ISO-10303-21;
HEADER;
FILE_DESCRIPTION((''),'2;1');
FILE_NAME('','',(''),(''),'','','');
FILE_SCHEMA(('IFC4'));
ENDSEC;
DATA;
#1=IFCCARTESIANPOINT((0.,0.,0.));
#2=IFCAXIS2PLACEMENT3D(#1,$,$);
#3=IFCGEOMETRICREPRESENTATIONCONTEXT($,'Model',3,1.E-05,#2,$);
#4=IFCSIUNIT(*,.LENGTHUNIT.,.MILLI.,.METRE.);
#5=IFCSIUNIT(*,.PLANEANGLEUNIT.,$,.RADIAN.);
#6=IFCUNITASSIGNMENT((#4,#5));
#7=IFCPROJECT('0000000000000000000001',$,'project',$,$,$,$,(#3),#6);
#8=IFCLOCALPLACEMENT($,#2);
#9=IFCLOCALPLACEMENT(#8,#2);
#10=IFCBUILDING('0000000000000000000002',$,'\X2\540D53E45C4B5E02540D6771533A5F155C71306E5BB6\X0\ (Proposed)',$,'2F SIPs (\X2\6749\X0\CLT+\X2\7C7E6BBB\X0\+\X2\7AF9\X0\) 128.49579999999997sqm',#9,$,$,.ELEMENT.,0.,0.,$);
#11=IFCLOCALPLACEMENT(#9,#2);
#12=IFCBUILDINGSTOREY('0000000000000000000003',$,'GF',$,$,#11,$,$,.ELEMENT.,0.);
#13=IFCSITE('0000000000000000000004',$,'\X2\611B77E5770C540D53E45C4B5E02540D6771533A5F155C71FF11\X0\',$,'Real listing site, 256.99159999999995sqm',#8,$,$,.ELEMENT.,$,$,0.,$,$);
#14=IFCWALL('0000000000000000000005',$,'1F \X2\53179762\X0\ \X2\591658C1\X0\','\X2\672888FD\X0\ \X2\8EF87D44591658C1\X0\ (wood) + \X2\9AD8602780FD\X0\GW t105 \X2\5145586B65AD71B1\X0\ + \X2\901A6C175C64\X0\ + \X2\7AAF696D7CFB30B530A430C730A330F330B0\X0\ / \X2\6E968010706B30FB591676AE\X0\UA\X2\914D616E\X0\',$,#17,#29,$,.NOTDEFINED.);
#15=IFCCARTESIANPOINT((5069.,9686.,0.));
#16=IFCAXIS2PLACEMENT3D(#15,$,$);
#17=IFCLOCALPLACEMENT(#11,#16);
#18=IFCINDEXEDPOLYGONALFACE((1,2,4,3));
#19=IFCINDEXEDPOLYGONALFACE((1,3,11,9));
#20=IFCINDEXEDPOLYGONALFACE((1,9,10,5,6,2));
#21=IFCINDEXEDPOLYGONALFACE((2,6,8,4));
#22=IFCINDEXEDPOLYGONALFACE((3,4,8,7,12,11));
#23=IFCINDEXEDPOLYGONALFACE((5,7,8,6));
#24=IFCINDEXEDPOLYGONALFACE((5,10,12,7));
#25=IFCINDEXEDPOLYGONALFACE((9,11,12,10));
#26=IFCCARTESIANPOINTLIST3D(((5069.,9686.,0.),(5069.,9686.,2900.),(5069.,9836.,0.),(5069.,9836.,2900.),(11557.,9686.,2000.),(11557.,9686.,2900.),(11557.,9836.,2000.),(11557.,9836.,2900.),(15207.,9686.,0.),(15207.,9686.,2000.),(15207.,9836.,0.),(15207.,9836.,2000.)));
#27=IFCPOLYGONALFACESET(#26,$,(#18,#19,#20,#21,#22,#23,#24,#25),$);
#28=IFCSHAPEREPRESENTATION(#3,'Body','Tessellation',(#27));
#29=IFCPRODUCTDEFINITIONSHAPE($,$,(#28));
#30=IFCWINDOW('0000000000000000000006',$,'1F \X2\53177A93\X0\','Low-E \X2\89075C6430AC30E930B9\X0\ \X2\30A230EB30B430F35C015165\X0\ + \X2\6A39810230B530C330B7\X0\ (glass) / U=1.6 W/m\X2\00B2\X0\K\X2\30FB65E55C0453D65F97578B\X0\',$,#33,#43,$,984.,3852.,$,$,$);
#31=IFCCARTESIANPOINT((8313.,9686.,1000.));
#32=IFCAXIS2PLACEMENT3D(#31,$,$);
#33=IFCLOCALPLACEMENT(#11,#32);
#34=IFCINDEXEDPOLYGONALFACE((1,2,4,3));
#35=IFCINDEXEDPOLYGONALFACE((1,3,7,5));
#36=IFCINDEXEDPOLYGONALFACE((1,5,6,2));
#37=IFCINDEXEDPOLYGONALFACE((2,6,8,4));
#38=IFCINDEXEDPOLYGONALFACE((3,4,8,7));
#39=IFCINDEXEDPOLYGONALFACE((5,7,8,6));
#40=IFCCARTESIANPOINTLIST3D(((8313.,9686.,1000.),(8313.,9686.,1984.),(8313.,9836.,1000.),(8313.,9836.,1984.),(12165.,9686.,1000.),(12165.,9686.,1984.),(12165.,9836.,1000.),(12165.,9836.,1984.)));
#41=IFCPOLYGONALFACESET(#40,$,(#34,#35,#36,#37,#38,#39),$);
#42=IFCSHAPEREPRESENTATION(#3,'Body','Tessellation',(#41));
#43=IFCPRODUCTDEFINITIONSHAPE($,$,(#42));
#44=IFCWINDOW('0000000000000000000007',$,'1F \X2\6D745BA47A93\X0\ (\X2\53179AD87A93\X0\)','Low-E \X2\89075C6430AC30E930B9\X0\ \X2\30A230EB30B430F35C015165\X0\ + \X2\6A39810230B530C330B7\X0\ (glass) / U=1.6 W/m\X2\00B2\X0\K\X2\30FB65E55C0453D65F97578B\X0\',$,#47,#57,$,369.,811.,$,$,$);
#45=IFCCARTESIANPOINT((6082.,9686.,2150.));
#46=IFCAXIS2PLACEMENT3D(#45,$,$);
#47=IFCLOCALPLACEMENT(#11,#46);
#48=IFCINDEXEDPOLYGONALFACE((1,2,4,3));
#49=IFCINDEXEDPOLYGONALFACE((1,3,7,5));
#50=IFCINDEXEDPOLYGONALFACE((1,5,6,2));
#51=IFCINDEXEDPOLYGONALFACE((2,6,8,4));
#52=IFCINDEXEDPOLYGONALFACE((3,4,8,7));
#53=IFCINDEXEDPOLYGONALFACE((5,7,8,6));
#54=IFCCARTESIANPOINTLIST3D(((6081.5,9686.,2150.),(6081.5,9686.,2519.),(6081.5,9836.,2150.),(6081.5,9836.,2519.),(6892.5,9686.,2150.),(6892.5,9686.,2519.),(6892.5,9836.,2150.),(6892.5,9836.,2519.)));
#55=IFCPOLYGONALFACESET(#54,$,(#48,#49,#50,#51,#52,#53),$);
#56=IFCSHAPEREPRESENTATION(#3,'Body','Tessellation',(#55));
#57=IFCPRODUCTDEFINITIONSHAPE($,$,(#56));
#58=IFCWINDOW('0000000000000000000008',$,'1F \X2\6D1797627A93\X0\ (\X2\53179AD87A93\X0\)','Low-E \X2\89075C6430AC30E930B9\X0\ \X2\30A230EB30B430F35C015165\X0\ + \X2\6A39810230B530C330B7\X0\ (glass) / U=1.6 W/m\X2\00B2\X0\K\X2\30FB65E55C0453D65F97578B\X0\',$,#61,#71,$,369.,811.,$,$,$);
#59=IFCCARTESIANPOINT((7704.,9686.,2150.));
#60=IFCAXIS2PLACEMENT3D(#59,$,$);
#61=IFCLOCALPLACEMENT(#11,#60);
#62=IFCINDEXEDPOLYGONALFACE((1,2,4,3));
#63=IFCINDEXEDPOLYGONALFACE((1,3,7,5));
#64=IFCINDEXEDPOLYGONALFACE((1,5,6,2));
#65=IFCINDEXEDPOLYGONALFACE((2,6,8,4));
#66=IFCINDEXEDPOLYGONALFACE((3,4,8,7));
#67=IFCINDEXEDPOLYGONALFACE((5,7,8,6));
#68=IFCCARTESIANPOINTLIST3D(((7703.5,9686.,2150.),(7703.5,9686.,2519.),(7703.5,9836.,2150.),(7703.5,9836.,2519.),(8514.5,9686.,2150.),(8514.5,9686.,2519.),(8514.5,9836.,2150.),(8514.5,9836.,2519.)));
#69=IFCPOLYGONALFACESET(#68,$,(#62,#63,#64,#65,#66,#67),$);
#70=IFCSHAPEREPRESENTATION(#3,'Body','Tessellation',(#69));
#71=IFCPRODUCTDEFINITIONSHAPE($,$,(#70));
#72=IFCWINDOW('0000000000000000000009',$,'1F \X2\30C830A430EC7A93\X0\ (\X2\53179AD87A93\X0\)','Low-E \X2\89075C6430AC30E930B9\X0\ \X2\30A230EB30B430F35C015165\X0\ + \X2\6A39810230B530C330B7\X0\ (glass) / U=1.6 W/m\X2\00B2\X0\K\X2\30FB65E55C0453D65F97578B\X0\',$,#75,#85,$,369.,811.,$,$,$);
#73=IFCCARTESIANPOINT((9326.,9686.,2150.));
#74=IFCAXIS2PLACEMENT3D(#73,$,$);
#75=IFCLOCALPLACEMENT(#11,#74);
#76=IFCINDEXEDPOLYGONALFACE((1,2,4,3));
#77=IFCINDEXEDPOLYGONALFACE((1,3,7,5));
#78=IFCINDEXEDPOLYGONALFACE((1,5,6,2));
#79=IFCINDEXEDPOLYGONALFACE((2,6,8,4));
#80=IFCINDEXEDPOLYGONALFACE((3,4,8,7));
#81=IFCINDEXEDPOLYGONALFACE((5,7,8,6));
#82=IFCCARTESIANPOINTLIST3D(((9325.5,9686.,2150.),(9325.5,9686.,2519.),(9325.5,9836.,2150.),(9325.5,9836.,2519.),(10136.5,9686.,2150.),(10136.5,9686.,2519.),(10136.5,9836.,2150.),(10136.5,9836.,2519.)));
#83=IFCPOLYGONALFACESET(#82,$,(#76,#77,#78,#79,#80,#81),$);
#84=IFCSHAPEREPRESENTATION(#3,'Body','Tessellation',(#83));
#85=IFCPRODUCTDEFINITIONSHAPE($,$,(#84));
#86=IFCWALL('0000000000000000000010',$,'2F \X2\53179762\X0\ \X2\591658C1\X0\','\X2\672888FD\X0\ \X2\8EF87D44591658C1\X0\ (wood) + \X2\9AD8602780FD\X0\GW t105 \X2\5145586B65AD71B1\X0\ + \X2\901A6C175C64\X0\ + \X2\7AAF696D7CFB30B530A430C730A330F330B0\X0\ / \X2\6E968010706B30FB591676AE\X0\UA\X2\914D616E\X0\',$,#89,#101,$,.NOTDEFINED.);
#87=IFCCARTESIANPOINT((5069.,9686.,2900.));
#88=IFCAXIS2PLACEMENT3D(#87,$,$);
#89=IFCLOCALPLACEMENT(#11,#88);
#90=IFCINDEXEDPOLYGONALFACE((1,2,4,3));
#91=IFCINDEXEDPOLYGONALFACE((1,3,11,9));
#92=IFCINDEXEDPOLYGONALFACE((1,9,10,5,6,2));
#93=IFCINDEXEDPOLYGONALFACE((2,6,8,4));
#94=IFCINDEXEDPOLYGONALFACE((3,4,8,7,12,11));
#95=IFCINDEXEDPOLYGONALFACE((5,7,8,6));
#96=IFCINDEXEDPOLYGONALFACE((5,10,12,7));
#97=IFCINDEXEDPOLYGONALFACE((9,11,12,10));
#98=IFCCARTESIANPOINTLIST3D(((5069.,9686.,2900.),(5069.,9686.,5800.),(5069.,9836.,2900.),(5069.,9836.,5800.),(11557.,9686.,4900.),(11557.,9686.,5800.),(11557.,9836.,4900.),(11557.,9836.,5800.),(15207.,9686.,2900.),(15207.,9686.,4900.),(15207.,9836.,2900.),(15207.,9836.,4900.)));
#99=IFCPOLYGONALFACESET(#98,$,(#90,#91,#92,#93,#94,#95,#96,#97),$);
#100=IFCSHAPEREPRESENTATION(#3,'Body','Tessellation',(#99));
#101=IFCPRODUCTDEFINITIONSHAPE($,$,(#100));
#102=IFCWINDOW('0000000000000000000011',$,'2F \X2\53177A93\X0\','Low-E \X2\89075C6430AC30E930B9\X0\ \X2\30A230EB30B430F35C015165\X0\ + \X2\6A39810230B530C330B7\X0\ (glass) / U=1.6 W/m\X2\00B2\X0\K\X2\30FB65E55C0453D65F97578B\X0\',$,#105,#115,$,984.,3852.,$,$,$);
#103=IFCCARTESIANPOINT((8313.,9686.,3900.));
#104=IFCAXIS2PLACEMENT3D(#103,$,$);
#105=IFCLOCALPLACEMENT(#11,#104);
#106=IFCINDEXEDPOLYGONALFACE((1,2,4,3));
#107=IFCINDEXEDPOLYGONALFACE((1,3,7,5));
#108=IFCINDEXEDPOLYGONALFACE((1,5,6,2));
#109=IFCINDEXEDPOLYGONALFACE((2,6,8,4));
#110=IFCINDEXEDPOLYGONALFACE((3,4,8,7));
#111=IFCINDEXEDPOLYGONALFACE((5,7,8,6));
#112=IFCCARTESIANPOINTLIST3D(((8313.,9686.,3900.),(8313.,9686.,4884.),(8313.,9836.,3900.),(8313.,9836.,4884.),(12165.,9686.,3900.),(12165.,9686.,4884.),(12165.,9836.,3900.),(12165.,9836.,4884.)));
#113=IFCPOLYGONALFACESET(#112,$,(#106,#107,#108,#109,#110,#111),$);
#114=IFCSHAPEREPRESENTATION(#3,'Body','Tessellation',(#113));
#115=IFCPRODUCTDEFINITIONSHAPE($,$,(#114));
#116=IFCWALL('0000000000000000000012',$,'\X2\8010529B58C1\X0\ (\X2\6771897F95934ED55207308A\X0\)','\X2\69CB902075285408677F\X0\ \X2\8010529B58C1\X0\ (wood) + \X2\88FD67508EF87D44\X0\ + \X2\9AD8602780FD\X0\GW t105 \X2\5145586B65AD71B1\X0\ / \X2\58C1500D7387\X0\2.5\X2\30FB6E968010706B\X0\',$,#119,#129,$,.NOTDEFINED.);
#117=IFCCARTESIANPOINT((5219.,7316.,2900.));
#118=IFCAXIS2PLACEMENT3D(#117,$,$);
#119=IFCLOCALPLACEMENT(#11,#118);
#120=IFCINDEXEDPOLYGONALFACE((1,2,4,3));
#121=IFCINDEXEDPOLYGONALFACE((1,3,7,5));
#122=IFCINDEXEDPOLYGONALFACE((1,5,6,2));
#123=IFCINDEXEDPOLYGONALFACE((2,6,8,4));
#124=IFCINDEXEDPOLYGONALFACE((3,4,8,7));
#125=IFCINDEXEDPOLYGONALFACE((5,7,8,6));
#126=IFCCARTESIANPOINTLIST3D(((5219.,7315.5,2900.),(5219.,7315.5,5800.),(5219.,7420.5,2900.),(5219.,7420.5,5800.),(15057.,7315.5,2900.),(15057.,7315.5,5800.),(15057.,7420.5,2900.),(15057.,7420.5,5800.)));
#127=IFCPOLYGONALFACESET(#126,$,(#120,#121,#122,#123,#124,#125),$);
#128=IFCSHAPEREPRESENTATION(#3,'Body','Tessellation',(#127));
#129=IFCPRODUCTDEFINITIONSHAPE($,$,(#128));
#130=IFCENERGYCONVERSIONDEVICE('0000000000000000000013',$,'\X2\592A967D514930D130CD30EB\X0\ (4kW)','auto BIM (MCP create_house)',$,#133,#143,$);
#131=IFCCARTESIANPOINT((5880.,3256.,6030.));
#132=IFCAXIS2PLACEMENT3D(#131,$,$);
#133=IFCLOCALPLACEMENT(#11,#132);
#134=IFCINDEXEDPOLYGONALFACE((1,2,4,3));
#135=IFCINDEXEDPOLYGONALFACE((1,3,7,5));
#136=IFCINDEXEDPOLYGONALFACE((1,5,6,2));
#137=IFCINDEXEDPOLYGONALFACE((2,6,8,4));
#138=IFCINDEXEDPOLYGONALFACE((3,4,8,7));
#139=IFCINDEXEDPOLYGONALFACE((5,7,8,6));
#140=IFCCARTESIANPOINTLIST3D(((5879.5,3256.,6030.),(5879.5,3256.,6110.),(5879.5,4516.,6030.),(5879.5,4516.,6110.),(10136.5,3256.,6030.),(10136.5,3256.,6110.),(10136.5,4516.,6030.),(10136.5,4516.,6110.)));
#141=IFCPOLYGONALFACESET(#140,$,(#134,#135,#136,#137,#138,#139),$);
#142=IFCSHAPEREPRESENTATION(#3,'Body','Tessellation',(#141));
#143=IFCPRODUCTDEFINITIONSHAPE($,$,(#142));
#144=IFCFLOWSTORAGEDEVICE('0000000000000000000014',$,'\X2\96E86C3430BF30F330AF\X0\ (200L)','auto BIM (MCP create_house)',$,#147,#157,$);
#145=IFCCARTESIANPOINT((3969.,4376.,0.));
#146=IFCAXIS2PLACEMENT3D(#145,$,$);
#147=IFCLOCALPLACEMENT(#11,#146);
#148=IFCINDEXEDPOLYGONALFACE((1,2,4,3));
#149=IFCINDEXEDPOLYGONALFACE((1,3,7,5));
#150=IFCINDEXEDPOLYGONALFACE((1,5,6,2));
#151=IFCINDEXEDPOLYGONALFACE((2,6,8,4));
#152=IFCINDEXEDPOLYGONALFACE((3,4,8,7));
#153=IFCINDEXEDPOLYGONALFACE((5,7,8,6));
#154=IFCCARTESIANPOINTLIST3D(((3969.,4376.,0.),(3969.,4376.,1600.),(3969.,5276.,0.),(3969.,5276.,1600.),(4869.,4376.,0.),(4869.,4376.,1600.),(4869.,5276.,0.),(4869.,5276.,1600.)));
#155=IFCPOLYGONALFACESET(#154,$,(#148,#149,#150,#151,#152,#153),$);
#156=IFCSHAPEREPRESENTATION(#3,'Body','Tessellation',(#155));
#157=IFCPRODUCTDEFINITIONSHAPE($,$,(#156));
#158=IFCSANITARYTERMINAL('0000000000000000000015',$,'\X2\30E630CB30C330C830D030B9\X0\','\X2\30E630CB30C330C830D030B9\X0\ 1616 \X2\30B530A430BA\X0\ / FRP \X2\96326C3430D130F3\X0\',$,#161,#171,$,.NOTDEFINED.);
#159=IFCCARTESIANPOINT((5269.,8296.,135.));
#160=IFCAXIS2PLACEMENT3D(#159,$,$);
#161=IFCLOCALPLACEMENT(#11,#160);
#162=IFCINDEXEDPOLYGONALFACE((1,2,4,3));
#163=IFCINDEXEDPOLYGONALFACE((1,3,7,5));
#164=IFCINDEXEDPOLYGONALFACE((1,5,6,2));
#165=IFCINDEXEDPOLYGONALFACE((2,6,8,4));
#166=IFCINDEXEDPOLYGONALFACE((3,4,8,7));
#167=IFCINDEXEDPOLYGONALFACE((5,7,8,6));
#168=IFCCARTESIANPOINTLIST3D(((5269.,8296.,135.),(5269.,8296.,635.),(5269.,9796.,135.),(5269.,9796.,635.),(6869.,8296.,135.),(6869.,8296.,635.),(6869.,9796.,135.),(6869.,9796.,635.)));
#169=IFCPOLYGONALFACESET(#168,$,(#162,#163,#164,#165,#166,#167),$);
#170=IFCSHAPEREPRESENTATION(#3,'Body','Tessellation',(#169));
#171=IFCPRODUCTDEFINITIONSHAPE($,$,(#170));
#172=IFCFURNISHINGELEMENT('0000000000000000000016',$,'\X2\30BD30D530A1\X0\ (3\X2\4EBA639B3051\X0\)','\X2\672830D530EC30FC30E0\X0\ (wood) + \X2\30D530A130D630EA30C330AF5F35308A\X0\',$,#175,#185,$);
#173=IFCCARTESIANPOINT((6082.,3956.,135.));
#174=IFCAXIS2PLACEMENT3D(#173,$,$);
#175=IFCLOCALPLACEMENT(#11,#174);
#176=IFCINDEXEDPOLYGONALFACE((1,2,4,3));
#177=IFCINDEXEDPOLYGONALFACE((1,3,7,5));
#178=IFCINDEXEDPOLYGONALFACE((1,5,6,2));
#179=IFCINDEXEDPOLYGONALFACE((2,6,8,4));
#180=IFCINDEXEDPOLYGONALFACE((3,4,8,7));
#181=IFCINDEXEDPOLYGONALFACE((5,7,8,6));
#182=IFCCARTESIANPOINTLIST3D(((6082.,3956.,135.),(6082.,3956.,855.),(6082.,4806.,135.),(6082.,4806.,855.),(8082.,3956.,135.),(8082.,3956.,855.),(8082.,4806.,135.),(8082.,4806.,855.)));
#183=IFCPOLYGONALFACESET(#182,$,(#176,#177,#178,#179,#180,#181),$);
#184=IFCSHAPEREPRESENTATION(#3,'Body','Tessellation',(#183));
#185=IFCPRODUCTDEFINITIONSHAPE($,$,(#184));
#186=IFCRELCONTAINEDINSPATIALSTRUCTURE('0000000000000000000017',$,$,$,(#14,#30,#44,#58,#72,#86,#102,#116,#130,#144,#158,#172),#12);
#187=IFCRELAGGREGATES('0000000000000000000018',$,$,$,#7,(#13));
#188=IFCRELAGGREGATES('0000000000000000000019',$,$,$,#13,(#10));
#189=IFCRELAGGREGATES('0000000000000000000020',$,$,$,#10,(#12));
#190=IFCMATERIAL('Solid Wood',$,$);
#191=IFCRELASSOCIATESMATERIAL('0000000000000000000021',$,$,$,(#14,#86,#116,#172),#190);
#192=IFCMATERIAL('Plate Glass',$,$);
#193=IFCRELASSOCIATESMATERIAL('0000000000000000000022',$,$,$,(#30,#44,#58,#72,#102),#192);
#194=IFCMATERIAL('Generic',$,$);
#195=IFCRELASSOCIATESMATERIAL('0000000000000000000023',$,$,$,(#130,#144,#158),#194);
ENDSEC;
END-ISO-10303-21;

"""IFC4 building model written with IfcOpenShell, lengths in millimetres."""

from ifc_helpers import new_model, si_unit, frame, frame_2d, origin, place, context, project, spatial, rectangle, extrude, material, element, fill, save


model = new_model("IFC4")

# Units and contexts
model_context = context("Model", 3, precision=1e-05, world=origin())
ifc_project = project(units=[si_unit("LENGTHUNIT", "METRE", prefix="MILLI"), si_unit("PLANEANGLEUNIT", "RADIAN")], contexts=[model_context])

# Site, building, storey
site_placement = place(None, origin())
site = spatial("IfcSite", under=ifc_project, at=site_placement, Name="愛知県名古屋市名東区引山１", ObjectType="Real listing site, 256.99159999999995sqm", CompositionType="ELEMENT", RefElevation=0.0)
building_placement = place(site_placement, origin())
building = spatial("IfcBuilding", under=site, at=building_placement, Name="名古屋市名東区引山の家 (Proposed)", ObjectType="2F SIPs (杉CLT+籾殻+竹) 128.49579999999997sqm", CompositionType="ELEMENT", ElevationOfRefHeight=0.0, ElevationOfTerrain=0.0)
storey_placement = place(building_placement, origin())
storey = spatial("IfcBuildingStorey", under=building, at=storey_placement, Name="GF", CompositionType="ELEMENT", Elevation=0.0)

# Wall, openings, windows
ifc_material_1 = material(Name="Solid Wood")
wall_1_placement = place(storey_placement, frame((5069.0, 9686.0, 0.0)))
wall_1 = element("IfcWall", 1, at=wall_1_placement, inside=storey, material=ifc_material_1, Name="1F 北面 外壁", Description="木製 軸組外壁 (wood) + 高性能GW t105 充填断熱 + 通気層 + 窯業系サイディング / 準耐火・外皮UA配慮", PredefinedType="NOTDEFINED", context=model_context, shape_type="SweptSolid", body=[
    extrude(rectangle(XDim=10138.0, YDim=150.0, at=frame_2d((5069.0, 75.0))), frame((5069.0, 9686.0, 0.0)), (0.0, 0.0, 1.0), 2900.0),
])
opening_1_placement = place(storey_placement, frame((8313.0, 9686.0, 1000.0)))
opening_1 = element("IfcOpeningElement", 2, at=opening_1_placement, cuts=wall_1, PredefinedType="NOTDEFINED", context=model_context, shape_type="SweptSolid", body=[
    extrude(rectangle(XDim=3852.0, YDim=150.0, at=frame_2d((1926.0, 75.0))), frame((8313.0, 9686.0, 1000.0)), (0.0, 0.0, 1.0), 984.0),
])
opening_2_placement = place(storey_placement, frame((6082.0, 9686.0, 2150.0)))
opening_2 = element("IfcOpeningElement", 3, at=opening_2_placement, cuts=wall_1, PredefinedType="NOTDEFINED", context=model_context, shape_type="SweptSolid", body=[
    extrude(rectangle(XDim=811.0, YDim=150.0, at=frame_2d((405.0, 75.0))), frame((6082.0, 9686.0, 2150.0)), (0.0, 0.0, 1.0), 369.0),
])
opening_3_placement = place(storey_placement, frame((7704.0, 9686.0, 2150.0)))
opening_3 = element("IfcOpeningElement", 4, at=opening_3_placement, cuts=wall_1, PredefinedType="NOTDEFINED", context=model_context, shape_type="SweptSolid", body=[
    extrude(rectangle(XDim=811.0, YDim=150.0, at=frame_2d((405.0, 75.0))), frame((7704.0, 9686.0, 2150.0)), (0.0, 0.0, 1.0), 369.0),
])
opening_4_placement = place(storey_placement, frame((9326.0, 9686.0, 2150.0)))
opening_4 = element("IfcOpeningElement", 5, at=opening_4_placement, cuts=wall_1, PredefinedType="NOTDEFINED", context=model_context, shape_type="SweptSolid", body=[
    extrude(rectangle(XDim=811.0, YDim=150.0, at=frame_2d((405.0, 75.0))), frame((9326.0, 9686.0, 2150.0)), (0.0, 0.0, 1.0), 369.0),
])
ifc_material_2 = material(Name="Plate Glass")
window_1_placement = place(storey_placement, frame((8313.0, 9686.0, 1000.0)))
window_1 = element("IfcWindow", 6, at=window_1_placement, inside=storey, material=ifc_material_2, Name="1F 北窓", Description="Low-E 複層ガラス アルゴン封入 + 樹脂サッシ (glass) / U=1.6 W/m²K・日射取得型", OverallHeight=984.0, OverallWidth=3852.0, context=model_context, shape_type="SweptSolid", body=[
    extrude(rectangle(XDim=3852.0, YDim=150.0, at=frame_2d((1926.0, 75.0))), frame((8313.0, 9686.0, 1000.0)), (0.0, 0.0, 1.0), 984.0),
])
fill(opening_1, window_1)
window_2_placement = place(storey_placement, frame((6082.0, 9686.0, 2150.0)))
window_2 = element("IfcWindow", 7, at=window_2_placement, inside=storey, material=ifc_material_2, Name="1F 浴室窓 (北高窓)", Description="Low-E 複層ガラス アルゴン封入 + 樹脂サッシ (glass) / U=1.6 W/m²K・日射取得型", OverallHeight=369.0, OverallWidth=811.0, context=model_context, shape_type="SweptSolid", body=[
    extrude(rectangle(XDim=811.0, YDim=150.0, at=frame_2d((405.0, 75.0))), frame((6082.0, 9686.0, 2150.0)), (0.0, 0.0, 1.0), 369.0),
])
fill(opening_2, window_2)
window_3_placement = place(storey_placement, frame((7704.0, 9686.0, 2150.0)))
window_3 = element("IfcWindow", 8, at=window_3_placement, inside=storey, material=ifc_material_2, Name="1F 洗面窓 (北高窓)", Description="Low-E 複層ガラス アルゴン封入 + 樹脂サッシ (glass) / U=1.6 W/m²K・日射取得型", OverallHeight=369.0, OverallWidth=811.0, context=model_context, shape_type="SweptSolid", body=[
    extrude(rectangle(XDim=811.0, YDim=150.0, at=frame_2d((405.0, 75.0))), frame((7704.0, 9686.0, 2150.0)), (0.0, 0.0, 1.0), 369.0),
])
fill(opening_3, window_3)
window_4_placement = place(storey_placement, frame((9326.0, 9686.0, 2150.0)))
window_4 = element("IfcWindow", 9, at=window_4_placement, inside=storey, material=ifc_material_2, Name="1F トイレ窓 (北高窓)", Description="Low-E 複層ガラス アルゴン封入 + 樹脂サッシ (glass) / U=1.6 W/m²K・日射取得型", OverallHeight=369.0, OverallWidth=811.0, context=model_context, shape_type="SweptSolid", body=[
    extrude(rectangle(XDim=811.0, YDim=150.0, at=frame_2d((405.0, 75.0))), frame((9326.0, 9686.0, 2150.0)), (0.0, 0.0, 1.0), 369.0),
])
fill(opening_4, window_4)

# Wall, opening, window
wall_2_placement = place(storey_placement, frame((5069.0, 9686.0, 2900.0)))
wall_2 = element("IfcWall", 10, at=wall_2_placement, inside=storey, material=ifc_material_1, Name="2F 北面 外壁", Description="木製 軸組外壁 (wood) + 高性能GW t105 充填断熱 + 通気層 + 窯業系サイディング / 準耐火・外皮UA配慮", PredefinedType="NOTDEFINED", context=model_context, shape_type="SweptSolid", body=[
    extrude(rectangle(XDim=10138.0, YDim=150.0, at=frame_2d((5069.0, 75.0))), frame((5069.0, 9686.0, 2900.0)), (0.0, 0.0, 1.0), 2900.0),
])
opening_5_placement = place(storey_placement, frame((8313.0, 9686.0, 3900.0)))
opening_5 = element("IfcOpeningElement", 11, at=opening_5_placement, cuts=wall_2, PredefinedType="NOTDEFINED", context=model_context, shape_type="SweptSolid", body=[
    extrude(rectangle(XDim=3852.0, YDim=150.0, at=frame_2d((1926.0, 75.0))), frame((8313.0, 9686.0, 3900.0)), (0.0, 0.0, 1.0), 984.0),
])
window_5_placement = place(storey_placement, frame((8313.0, 9686.0, 3900.0)))
window_5 = element("IfcWindow", 12, at=window_5_placement, inside=storey, material=ifc_material_2, Name="2F 北窓", Description="Low-E 複層ガラス アルゴン封入 + 樹脂サッシ (glass) / U=1.6 W/m²K・日射取得型", OverallHeight=984.0, OverallWidth=3852.0, context=model_context, shape_type="SweptSolid", body=[
    extrude(rectangle(XDim=3852.0, YDim=150.0, at=frame_2d((1926.0, 75.0))), frame((8313.0, 9686.0, 3900.0)), (0.0, 0.0, 1.0), 984.0),
])
fill(opening_5, window_5)

# Wall
wall_3_placement = place(storey_placement, frame((5219.0, 7316.0, 2900.0)))
element("IfcWall", 13, at=wall_3_placement, inside=storey, material=ifc_material_1, Name="耐力壁 (東西間仕切り)", Description="構造用合板 耐力壁 (wood) + 製材軸組 + 高性能GW t105 充填断熱 / 壁倍率2.5・準耐火", PredefinedType="NOTDEFINED", context=model_context, shape_type="SweptSolid", body=[
    extrude(rectangle(XDim=9838.0, YDim=105.0, at=frame_2d((4919.0, 52.0))), frame((5219.0, 7316.0, 2900.0)), (0.0, 0.0, 1.0), 2900.0),
])

# Energy conversion device
ifc_material_3 = material(Name="Generic")
energy_conversion_device_placement = place(storey_placement, frame((5880.0, 3256.0, 6030.0)))
element("IfcEnergyConversionDevice", 14, at=energy_conversion_device_placement, inside=storey, material=ifc_material_3, Name="太陽光パネル (4kW)", Description="auto BIM (MCP create_house)", context=model_context, shape_type="SweptSolid", body=[
    extrude(rectangle(XDim=4257.0, YDim=1260.0, at=frame_2d((2128.0, 630.0))), frame((5880.0, 3256.0, 6030.0)), (0.0, 0.0, 1.0), 80.0),
])

# Flow storage device
flow_storage_device_placement = place(storey_placement, frame((3969.0, 4376.0, 0.0)))
element("IfcFlowStorageDevice", 15, at=flow_storage_device_placement, inside=storey, material=ifc_material_3, Name="雨水タンク (200L)", Description="auto BIM (MCP create_house)", context=model_context, shape_type="SweptSolid", body=[
    extrude(rectangle(XDim=900.0, YDim=900.0, at=frame_2d((450.0, 450.0))), frame((3969.0, 4376.0, 0.0)), (0.0, 0.0, 1.0), 1600.0),
])

# Sanitary terminal
sanitary_terminal_placement = place(storey_placement, frame((5269.0, 8296.0, 135.0)))
element("IfcSanitaryTerminal", 16, at=sanitary_terminal_placement, inside=storey, material=ifc_material_3, Name="ユニットバス", Description="ユニットバス 1616 サイズ / FRP 防水パン", PredefinedType="NOTDEFINED", context=model_context, shape_type="SweptSolid", body=[
    extrude(rectangle(XDim=1600.0, YDim=1500.0, at=frame_2d((800.0, 750.0))), frame((5269.0, 8296.0, 135.0)), (0.0, 0.0, 1.0), 500.0),
])

# Furnishing element
furnishing_1_placement = place(storey_placement, frame((6082.0, 3956.0, 135.0)))
element("IfcFurnishingElement", 17, at=furnishing_1_placement, inside=storey, material=ifc_material_1, Name="ソファ (3人掛け)", Description="木フレーム (wood) + ファブリック張り", context=model_context, shape_type="SweptSolid", body=[
    extrude(rectangle(XDim=2000.0, YDim=850.0, at=frame_2d((1000.0, 425.0))), frame((6082.0, 3956.0, 135.0)), (0.0, 0.0, 1.0), 720.0),
])

save(model, "model.ifc")
